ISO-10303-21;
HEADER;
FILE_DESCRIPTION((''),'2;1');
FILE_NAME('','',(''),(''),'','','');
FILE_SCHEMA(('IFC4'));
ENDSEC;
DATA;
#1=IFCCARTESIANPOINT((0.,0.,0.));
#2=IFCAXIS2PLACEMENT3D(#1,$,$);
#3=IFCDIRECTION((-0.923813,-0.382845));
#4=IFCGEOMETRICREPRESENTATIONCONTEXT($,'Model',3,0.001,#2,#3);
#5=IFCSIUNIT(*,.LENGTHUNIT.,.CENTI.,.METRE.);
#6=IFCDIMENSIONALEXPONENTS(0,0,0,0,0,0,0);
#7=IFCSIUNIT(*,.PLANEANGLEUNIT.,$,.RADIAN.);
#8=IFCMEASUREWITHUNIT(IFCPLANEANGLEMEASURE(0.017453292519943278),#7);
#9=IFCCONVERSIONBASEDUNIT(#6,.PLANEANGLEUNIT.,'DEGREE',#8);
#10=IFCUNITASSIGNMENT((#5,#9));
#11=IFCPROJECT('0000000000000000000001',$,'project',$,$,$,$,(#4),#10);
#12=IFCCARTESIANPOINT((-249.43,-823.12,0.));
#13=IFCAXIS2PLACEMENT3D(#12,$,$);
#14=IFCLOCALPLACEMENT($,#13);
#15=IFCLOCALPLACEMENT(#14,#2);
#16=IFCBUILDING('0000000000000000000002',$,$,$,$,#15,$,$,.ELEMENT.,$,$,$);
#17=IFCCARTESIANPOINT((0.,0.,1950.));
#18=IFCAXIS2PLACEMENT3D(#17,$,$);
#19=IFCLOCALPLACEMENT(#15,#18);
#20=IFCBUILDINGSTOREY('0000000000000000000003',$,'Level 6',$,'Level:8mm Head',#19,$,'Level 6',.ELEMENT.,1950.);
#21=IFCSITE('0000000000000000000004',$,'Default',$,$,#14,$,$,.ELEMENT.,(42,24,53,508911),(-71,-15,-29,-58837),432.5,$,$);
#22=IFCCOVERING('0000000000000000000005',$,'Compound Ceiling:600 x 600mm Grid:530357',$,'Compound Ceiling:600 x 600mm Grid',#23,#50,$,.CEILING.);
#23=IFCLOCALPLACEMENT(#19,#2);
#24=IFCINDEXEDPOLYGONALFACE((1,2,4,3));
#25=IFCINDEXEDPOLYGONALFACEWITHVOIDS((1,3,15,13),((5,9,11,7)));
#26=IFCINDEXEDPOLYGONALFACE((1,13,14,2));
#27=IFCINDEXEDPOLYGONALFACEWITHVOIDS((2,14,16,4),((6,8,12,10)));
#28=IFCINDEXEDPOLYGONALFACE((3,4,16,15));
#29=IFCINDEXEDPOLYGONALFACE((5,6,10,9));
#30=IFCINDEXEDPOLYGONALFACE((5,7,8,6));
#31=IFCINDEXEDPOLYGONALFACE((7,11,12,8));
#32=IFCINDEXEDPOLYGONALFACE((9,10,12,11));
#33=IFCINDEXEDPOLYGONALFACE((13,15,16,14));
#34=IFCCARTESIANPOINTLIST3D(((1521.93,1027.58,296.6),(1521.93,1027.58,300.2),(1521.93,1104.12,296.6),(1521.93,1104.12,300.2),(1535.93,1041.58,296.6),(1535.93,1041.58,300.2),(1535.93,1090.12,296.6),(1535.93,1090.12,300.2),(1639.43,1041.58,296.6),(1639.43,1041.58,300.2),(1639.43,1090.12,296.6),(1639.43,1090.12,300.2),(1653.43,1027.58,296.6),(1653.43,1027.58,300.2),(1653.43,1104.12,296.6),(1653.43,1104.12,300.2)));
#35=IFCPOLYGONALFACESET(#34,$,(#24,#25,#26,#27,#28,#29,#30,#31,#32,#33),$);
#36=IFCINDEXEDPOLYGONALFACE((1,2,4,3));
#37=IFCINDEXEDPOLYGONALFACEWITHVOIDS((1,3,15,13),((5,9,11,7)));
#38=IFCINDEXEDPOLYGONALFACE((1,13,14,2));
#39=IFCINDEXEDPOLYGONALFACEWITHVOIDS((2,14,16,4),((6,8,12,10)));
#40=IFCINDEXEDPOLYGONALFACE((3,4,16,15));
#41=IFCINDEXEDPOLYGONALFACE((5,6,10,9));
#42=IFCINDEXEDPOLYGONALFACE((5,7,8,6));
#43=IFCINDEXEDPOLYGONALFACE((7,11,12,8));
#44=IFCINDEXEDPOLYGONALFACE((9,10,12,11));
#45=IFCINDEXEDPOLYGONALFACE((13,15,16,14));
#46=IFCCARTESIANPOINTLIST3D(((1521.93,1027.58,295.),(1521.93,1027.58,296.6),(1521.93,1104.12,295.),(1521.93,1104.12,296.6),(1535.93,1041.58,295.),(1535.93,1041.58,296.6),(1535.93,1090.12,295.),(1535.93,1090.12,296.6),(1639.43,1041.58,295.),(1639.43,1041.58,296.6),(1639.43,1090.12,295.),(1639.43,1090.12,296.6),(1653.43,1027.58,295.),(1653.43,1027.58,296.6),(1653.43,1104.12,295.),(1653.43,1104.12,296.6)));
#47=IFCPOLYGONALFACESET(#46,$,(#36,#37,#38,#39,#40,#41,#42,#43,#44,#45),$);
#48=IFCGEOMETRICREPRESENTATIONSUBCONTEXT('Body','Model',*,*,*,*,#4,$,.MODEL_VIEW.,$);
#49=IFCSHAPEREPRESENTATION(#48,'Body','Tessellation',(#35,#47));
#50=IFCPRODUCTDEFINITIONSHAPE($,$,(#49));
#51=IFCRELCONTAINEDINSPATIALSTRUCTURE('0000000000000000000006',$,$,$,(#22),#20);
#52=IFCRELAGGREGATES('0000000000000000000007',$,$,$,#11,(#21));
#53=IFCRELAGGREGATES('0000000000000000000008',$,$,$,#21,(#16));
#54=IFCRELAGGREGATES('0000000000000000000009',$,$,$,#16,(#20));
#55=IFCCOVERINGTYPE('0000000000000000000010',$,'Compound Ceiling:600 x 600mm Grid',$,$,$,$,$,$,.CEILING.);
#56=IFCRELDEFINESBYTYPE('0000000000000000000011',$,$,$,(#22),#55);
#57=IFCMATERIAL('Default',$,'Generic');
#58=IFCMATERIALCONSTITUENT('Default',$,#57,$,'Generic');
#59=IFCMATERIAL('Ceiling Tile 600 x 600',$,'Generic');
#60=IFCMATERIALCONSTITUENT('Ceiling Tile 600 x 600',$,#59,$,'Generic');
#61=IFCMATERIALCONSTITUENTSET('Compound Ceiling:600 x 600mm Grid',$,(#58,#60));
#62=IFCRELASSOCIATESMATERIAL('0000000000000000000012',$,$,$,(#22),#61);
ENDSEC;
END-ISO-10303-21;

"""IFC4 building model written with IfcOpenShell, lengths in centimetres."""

from ifc_helpers import new_model, entity, si_unit, converted_unit, direction, frame, origin, place, context, subcontext, project, spatial, indexed_curve, outline, extrude, material, constituent, constituent_set, type_object, element, save


model = new_model("IFC4")

# Units and contexts
model_context = context("Model", 3, precision=0.001, world=origin(), true_north=direction((-0.923813, -0.382845)))
body_context = subcontext(model_context, "Body", "Model", "MODEL_VIEW")
ifc_project = project(units=[si_unit("LENGTHUNIT", "METRE", prefix="CENTI"), converted_unit("PLANEANGLEUNIT", "DEGREE", entity("IfcPlaneAngleMeasure", 0.017453292519943278), si_unit("PLANEANGLEUNIT", "RADIAN"), dimensions=[0, 0, 0, 0, 0, 0, 0])], contexts=[model_context])

# Site, building, storey
site_placement = place(None, frame((-249.43, -823.12, 0.0)))
site = spatial("IfcSite", under=ifc_project, at=site_placement, Name="Default", CompositionType="ELEMENT", RefLatitude=(42, 24, 53, 508911), RefLongitude=(-71, -15, -29, -58837), RefElevation=432.5)
building_placement = place(site_placement, origin())
building = spatial("IfcBuilding", under=site, at=building_placement, CompositionType="ELEMENT")
storey_placement = place(building_placement, frame((0.0, 0.0, 1950.0)))
storey = spatial("IfcBuildingStorey", under=building, at=storey_placement, Name="Level 6", ObjectType="Level:8mm Head", LongName="Level 6", CompositionType="ELEMENT", Elevation=1950.0)

# Covering
ifc_material_1 = material(Name="Default", Category="Generic")
ifc_constituent_1 = constituent(ifc_material_1, Name="Default", Category="Generic")
ifc_material_2 = material(Name="Ceiling Tile 600 x 600", Category="Generic")
ifc_constituent_2 = constituent(ifc_material_2, Name="Ceiling Tile 600 x 600", Category="Generic")
ifc_constituent_set_1 = constituent_set(constituents=[ifc_constituent_1, ifc_constituent_2], Name="Compound Ceiling:600 x 600mm Grid")
covering_type = type_object("IfcCoveringType", Name="Compound Ceiling:600 x 600mm Grid", PredefinedType="CEILING")
covering_1_placement = place(storey_placement, origin())
element("IfcCovering", 1, at=covering_1_placement, inside=storey, type_object=covering_type, material=ifc_constituent_set_1, Name="Compound Ceiling:600 x 600mm Grid:530357", ObjectType="Compound Ceiling:600 x 600mm Grid", PredefinedType="CEILING", context=body_context, shape_type="SweptSolid", body=[
    extrude(outline(indexed_curve([(-38.27, -65.75), (38.27, -65.75), (38.27, 65.75), (-38.27, 65.75), (-38.27, -65.75)], self_intersect=False), holes=[indexed_curve([(24.27, -51.75), (-24.27, -51.75), (-24.27, 51.75), (24.27, 51.75), (24.27, -51.75)], self_intersect=False)]), frame((1587.68, 1065.85, 296.6), z_axis=(0.0, 0.0, 1.0), x_axis=(0.0, -1.0, 0.0)), (0.0, 0.0, 1.0), 3.6),
    extrude(outline(indexed_curve([(-65.75, -38.27), (65.75, -38.27), (65.75, 38.27), (-65.75, 38.27), (-65.75, -38.27)], self_intersect=False), holes=[indexed_curve([(-51.75, 24.27), (51.75, 24.27), (51.75, -24.27), (-51.75, -24.27), (-51.75, 24.27)], self_intersect=False)]), frame((1587.68, 1065.85, 295.0), z_axis=(0.0, 0.0, 1.0), x_axis=(-1.0, 0.0, 0.0)), (0.0, 0.0, 1.0), 1.6),
])

save(model, "model.ifc")
